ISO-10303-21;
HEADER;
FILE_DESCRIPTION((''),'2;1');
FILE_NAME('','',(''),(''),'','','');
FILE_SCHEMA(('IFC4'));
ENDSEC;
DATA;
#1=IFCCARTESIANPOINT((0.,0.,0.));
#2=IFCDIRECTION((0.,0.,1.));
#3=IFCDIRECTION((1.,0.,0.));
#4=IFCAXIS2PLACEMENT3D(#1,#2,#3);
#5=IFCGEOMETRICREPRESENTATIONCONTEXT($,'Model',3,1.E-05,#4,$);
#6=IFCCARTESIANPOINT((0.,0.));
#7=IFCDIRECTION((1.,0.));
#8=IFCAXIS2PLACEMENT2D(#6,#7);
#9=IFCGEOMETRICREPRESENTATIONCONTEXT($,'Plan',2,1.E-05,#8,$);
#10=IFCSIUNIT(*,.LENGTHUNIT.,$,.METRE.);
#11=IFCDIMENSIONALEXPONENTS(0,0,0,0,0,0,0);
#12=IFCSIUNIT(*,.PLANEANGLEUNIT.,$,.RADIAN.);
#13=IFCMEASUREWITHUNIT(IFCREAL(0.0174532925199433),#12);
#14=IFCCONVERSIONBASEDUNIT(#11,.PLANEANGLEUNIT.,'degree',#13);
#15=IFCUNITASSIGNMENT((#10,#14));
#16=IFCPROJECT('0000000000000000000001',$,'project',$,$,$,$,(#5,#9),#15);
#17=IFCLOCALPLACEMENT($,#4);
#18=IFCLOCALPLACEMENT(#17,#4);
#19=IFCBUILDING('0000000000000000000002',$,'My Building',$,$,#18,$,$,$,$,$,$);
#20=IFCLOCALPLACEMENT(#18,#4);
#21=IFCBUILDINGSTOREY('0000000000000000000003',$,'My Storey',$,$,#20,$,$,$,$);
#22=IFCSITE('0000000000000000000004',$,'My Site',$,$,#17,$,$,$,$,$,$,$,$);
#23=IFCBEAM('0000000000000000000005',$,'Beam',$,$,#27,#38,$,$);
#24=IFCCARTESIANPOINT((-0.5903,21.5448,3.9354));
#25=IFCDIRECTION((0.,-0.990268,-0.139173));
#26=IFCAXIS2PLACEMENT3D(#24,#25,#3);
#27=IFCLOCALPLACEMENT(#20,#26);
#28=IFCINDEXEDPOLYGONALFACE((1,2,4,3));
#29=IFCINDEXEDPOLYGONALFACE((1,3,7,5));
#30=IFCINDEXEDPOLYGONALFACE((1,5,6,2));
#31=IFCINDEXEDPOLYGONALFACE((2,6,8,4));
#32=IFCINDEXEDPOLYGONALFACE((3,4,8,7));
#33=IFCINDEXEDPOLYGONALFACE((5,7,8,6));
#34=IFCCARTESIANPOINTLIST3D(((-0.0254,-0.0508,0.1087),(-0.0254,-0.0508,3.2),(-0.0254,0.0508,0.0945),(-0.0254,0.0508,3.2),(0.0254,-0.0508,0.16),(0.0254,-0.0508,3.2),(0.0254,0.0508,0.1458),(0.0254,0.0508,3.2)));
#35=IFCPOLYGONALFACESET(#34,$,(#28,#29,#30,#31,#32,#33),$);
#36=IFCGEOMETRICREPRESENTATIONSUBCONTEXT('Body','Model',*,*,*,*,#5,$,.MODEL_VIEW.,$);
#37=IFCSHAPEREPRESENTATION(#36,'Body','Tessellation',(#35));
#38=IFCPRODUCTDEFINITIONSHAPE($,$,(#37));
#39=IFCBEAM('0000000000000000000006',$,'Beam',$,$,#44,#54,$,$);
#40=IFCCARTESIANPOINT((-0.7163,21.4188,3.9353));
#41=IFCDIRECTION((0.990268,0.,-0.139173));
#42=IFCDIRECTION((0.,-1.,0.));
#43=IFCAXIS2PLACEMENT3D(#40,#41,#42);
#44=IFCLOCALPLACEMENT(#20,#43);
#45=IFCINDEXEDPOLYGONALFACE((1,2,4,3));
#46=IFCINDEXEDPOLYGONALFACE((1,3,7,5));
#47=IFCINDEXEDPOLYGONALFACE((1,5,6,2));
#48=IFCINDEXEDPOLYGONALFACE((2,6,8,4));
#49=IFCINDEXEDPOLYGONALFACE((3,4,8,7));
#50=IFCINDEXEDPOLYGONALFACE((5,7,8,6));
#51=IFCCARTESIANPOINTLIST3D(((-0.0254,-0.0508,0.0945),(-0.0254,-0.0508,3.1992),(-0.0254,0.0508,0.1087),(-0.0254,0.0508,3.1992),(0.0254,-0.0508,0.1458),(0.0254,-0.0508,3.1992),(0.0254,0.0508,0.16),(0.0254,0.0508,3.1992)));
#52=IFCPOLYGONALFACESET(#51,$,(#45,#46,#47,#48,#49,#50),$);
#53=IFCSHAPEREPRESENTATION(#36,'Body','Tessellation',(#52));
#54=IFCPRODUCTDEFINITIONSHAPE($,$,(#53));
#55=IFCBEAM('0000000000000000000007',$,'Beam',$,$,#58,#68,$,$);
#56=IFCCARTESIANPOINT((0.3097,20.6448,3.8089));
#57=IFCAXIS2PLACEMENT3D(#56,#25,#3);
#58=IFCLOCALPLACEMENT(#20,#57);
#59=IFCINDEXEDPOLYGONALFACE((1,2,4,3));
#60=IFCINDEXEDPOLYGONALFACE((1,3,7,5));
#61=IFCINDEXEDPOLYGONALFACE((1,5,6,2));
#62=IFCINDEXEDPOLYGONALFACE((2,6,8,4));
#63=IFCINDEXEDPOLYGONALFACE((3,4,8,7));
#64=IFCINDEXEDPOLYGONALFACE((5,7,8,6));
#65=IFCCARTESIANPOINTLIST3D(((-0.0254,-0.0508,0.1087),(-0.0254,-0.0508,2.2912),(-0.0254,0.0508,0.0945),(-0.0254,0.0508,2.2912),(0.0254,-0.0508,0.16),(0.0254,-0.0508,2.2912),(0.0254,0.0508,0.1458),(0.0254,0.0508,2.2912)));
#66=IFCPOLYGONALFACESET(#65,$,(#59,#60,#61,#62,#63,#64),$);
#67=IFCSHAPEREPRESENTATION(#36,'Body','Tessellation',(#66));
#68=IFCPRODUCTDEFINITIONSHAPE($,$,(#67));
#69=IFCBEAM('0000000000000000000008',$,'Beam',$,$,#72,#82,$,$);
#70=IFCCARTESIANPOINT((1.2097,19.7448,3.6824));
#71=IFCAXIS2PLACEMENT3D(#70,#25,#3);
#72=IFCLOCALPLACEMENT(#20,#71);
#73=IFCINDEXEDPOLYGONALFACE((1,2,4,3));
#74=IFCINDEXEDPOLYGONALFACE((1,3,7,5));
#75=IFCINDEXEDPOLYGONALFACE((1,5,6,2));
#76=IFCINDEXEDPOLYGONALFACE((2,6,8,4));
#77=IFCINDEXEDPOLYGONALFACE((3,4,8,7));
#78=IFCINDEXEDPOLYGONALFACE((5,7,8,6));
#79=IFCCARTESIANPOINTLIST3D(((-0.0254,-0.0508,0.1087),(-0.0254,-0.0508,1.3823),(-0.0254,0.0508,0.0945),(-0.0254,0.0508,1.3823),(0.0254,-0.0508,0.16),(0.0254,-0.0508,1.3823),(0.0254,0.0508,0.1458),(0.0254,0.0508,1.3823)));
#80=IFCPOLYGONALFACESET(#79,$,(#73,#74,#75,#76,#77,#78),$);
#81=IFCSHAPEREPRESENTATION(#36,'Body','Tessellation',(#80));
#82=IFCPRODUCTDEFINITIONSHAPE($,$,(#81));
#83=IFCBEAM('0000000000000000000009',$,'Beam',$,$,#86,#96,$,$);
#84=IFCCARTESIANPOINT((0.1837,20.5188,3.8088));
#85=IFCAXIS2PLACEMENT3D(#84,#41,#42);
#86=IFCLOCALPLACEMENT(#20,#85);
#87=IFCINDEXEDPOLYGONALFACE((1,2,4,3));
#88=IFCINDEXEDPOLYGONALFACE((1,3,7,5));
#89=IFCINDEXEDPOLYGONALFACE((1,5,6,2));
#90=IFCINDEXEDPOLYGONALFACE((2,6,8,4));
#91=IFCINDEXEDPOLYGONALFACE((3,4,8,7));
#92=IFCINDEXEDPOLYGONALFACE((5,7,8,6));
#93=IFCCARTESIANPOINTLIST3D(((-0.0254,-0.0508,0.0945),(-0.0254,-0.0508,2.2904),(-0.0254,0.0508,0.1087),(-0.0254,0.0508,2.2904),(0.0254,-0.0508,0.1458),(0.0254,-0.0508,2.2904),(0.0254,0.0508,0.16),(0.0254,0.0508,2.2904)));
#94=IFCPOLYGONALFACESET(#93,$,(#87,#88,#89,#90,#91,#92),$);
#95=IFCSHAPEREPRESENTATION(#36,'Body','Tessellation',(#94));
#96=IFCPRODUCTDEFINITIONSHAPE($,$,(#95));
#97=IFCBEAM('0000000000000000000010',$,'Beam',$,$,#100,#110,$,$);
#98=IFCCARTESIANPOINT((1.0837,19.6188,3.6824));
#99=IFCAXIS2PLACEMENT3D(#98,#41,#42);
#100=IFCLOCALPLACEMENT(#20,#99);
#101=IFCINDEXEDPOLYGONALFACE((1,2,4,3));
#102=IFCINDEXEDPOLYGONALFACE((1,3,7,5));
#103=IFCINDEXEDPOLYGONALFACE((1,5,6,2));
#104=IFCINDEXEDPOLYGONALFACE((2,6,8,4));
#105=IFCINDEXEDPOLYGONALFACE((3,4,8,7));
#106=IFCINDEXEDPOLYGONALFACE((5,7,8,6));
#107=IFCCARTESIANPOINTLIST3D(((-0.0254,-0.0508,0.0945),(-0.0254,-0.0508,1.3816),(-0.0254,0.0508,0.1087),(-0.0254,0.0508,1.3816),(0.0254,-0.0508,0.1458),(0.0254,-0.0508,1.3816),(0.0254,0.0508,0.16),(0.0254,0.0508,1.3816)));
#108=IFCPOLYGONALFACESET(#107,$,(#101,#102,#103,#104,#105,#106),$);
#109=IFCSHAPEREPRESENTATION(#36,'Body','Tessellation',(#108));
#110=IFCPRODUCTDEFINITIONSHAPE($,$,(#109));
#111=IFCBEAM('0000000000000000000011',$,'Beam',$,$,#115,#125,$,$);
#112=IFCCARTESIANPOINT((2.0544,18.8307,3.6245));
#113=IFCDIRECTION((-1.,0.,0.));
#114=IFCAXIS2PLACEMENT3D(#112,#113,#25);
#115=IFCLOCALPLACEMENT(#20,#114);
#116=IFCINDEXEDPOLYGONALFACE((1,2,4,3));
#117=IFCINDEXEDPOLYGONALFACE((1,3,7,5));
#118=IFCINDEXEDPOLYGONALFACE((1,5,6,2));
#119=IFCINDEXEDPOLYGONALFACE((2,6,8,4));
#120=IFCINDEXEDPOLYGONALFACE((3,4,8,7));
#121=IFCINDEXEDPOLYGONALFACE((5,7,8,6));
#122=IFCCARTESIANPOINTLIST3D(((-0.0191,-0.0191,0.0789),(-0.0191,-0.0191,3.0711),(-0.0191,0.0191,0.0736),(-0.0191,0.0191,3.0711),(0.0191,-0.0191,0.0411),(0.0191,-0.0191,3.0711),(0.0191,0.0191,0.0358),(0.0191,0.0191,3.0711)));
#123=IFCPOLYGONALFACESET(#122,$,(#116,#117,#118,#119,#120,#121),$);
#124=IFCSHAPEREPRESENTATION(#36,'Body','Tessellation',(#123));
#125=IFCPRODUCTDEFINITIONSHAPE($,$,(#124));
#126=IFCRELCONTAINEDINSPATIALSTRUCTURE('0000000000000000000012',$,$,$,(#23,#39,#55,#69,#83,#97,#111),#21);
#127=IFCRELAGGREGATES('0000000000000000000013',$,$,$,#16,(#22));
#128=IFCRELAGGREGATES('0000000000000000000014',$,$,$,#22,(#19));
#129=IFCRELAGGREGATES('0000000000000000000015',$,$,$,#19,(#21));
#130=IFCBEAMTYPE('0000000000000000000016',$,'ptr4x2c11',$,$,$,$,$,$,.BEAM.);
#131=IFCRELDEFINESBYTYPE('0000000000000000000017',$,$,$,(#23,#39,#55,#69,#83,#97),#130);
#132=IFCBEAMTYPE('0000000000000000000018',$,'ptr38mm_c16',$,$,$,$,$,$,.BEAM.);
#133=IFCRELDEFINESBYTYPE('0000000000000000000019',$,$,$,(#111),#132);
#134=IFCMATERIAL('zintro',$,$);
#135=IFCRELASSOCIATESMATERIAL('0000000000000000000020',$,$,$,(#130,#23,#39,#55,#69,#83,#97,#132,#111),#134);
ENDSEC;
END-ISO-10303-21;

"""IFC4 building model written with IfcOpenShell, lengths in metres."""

from ifc_helpers import new_model, entity, si_unit, converted_unit, frame, origin_with_axes, origin_2d_with_axis, place, context, subcontext, project, spatial, rectangle, extrude, clip, halfspace, material, material_profile, profile_set, profile_usage, type_object, element, save


model = new_model("IFC4")

# Units and contexts
model_context = context("Model", 3, precision=1e-05, world=origin_with_axes())
plan_context = context("Plan", 2, precision=1e-05, world=origin_2d_with_axis())
body_context = subcontext(model_context, "Body", "Model", "MODEL_VIEW")
ifc_project = project(units=[si_unit("LENGTHUNIT", "METRE"), converted_unit("PLANEANGLEUNIT", "degree", entity("IfcReal", 0.0174532925199433), si_unit("PLANEANGLEUNIT", "RADIAN"), dimensions=[0, 0, 0, 0, 0, 0, 0])], contexts=[model_context, plan_context])

# Site, building, storey
site_placement = place(None, origin_with_axes())
site = spatial("IfcSite", under=ifc_project, at=site_placement, Name="My Site")
building_placement = place(site_placement, origin_with_axes())
building = spatial("IfcBuilding", under=site, at=building_placement, Name="My Building")
storey_placement = place(building_placement, origin_with_axes())
storey = spatial("IfcBuildingStorey", under=building, at=storey_placement, Name="My Storey")

# Beams
ifc_material_1 = material(Name="zintro")
ifc_material_profile_1 = material_profile(ifc_material_1, rectangle(XDim=0.0508, YDim=0.1016))
ifc_profile_set_1 = profile_set([ifc_material_profile_1])
ifc_profile_usage_1 = profile_usage(ifc_profile_set_1)
beam_type_1 = type_object("IfcBeamType", Name="ptr4x2c11", PredefinedType="BEAM", material=ifc_profile_set_1)
beam_1_placement = place(storey_placement, frame((-0.5903, 21.5448, 3.9354), z_axis=(0.0, -0.990268, -0.139173), x_axis=(1.0, 0.0, 0.0)))
element("IfcBeam", 1, at=beam_1_placement, inside=storey, type_object=beam_type_1, material=ifc_profile_usage_1, Name="Beam", context=body_context, shape_type="Clipping", body=[
    clip(extrude(rectangle(XDim=0.0508, YDim=0.1016), origin_with_axes(), (0.0, 0.0, 1.0), 3.2), halfspace(frame((-0.0254, -3.8831, 0.6473), z_axis=(0.707109, -0.09841, -0.700223), x_axis=(0.707104, 0.098411, 0.700228)), False)),
])
ifc_profile_usage_2 = profile_usage(ifc_profile_set_1)
beam_2_placement = place(storey_placement, frame((-0.7163, 21.4188, 3.9353), z_axis=(0.990268, 0.0, -0.139173), x_axis=(0.0, -1.0, 0.0)))
element("IfcBeam", 2, at=beam_2_placement, inside=storey, type_object=beam_type_1, material=ifc_profile_usage_2, Name="Beam", context=body_context, shape_type="Clipping", body=[
    clip(extrude(rectangle(XDim=0.0508, YDim=0.1016), origin_with_axes(), (0.0, 0.0, 1.0), 3.1992), halfspace(frame((-0.0254, 3.883, 0.6473), z_axis=(0.707104, 0.098411, -0.700228), x_axis=(0.707109, -0.09841, 0.700223)), False)),
])
ifc_profile_usage_3 = profile_usage(ifc_profile_set_1)
beam_3_placement = place(storey_placement, frame((0.3097, 20.6448, 3.8089), z_axis=(0.0, -0.990268, -0.139173), x_axis=(1.0, 0.0, 0.0)))
element("IfcBeam", 3, at=beam_3_placement, inside=storey, type_object=beam_type_1, material=ifc_profile_usage_3, Name="Beam", context=body_context, shape_type="Clipping", body=[
    clip(extrude(rectangle(XDim=0.0508, YDim=0.1016), origin_with_axes(), (0.0, 0.0, 1.0), 2.2912), halfspace(frame((-0.0254, -3.7578, 0.6297), z_axis=(0.707109, -0.09841, -0.700223), x_axis=(0.707105, 0.09841, 0.700227)), False)),
])
ifc_profile_usage_4 = profile_usage(ifc_profile_set_1)
beam_4_placement = place(storey_placement, frame((1.2097, 19.7448, 3.6824), z_axis=(0.0, -0.990268, -0.139173), x_axis=(1.0, 0.0, 0.0)))
element("IfcBeam", 4, at=beam_4_placement, inside=storey, type_object=beam_type_1, material=ifc_profile_usage_4, Name="Beam", context=body_context, shape_type="Clipping", body=[
    clip(extrude(rectangle(XDim=0.0508, YDim=0.1016), origin_with_axes(), (0.0, 0.0, 1.0), 1.3823), halfspace(frame((-0.0254, -3.6326, 0.6121), z_axis=(0.707108, -0.09841, -0.700224), x_axis=(0.707105, 0.09841, 0.700227)), False)),
])
ifc_profile_usage_5 = profile_usage(ifc_profile_set_1)
beam_5_placement = place(storey_placement, frame((0.1837, 20.5188, 3.8088), z_axis=(0.990268, 0.0, -0.139173), x_axis=(0.0, -1.0, 0.0)))
element("IfcBeam", 5, at=beam_5_placement, inside=storey, type_object=beam_type_1, material=ifc_profile_usage_5, Name="Beam", context=body_context, shape_type="Clipping", body=[
    clip(extrude(rectangle(XDim=0.0508, YDim=0.1016), origin_with_axes(), (0.0, 0.0, 1.0), 2.2904), halfspace(frame((-0.0254, 3.7578, 0.6297), z_axis=(0.707105, 0.09841, -0.700227), x_axis=(0.707109, -0.09841, 0.700223)), False)),
])
ifc_profile_usage_6 = profile_usage(ifc_profile_set_1)
beam_6_placement = place(storey_placement, frame((1.0837, 19.6188, 3.6824), z_axis=(0.990268, 0.0, -0.139173), x_axis=(0.0, -1.0, 0.0)))
element("IfcBeam", 6, at=beam_6_placement, inside=storey, type_object=beam_type_1, material=ifc_profile_usage_6, Name="Beam", context=body_context, shape_type="Clipping", body=[
    clip(extrude(rectangle(XDim=0.0508, YDim=0.1016), origin_with_axes(), (0.0, 0.0, 1.0), 1.3816), halfspace(frame((-0.0254, 3.6325, 0.6121), z_axis=(0.707105, 0.09841, -0.700227), x_axis=(0.707109, -0.09841, 0.700224)), False)),
])
ifc_material_profile_2 = material_profile(ifc_material_1, rectangle(XDim=0.0381, YDim=0.0381))
ifc_profile_set_2 = profile_set([ifc_material_profile_2])
ifc_profile_usage_7 = profile_usage(ifc_profile_set_2)
beam_type_2 = type_object("IfcBeamType", Name="ptr38mm_c16", PredefinedType="BEAM", material=ifc_profile_set_2)
beam_7_placement = place(storey_placement, frame((2.0544, 18.8307, 3.6245), z_axis=(-1.0, 0.0, 0.0), x_axis=(0.0, -0.990268, -0.139173)))
element("IfcBeam", 7, at=beam_7_placement, inside=storey, type_object=beam_type_2, material=ifc_profile_usage_7, Name="Beam", context=body_context, shape_type="Clipping", body=[
    clip(extrude(rectangle(XDim=0.0381, YDim=0.0381), origin_with_axes(), (0.0, 0.0, 1.0), 3.0711), halfspace(frame((0.019, -1.2253, 0.209), z_axis=(-0.700246, -0.098408, -0.707087), x_axis=(-0.713902, 0.096533, 0.69356)), False)),
])

save(model, "model.ifc")
